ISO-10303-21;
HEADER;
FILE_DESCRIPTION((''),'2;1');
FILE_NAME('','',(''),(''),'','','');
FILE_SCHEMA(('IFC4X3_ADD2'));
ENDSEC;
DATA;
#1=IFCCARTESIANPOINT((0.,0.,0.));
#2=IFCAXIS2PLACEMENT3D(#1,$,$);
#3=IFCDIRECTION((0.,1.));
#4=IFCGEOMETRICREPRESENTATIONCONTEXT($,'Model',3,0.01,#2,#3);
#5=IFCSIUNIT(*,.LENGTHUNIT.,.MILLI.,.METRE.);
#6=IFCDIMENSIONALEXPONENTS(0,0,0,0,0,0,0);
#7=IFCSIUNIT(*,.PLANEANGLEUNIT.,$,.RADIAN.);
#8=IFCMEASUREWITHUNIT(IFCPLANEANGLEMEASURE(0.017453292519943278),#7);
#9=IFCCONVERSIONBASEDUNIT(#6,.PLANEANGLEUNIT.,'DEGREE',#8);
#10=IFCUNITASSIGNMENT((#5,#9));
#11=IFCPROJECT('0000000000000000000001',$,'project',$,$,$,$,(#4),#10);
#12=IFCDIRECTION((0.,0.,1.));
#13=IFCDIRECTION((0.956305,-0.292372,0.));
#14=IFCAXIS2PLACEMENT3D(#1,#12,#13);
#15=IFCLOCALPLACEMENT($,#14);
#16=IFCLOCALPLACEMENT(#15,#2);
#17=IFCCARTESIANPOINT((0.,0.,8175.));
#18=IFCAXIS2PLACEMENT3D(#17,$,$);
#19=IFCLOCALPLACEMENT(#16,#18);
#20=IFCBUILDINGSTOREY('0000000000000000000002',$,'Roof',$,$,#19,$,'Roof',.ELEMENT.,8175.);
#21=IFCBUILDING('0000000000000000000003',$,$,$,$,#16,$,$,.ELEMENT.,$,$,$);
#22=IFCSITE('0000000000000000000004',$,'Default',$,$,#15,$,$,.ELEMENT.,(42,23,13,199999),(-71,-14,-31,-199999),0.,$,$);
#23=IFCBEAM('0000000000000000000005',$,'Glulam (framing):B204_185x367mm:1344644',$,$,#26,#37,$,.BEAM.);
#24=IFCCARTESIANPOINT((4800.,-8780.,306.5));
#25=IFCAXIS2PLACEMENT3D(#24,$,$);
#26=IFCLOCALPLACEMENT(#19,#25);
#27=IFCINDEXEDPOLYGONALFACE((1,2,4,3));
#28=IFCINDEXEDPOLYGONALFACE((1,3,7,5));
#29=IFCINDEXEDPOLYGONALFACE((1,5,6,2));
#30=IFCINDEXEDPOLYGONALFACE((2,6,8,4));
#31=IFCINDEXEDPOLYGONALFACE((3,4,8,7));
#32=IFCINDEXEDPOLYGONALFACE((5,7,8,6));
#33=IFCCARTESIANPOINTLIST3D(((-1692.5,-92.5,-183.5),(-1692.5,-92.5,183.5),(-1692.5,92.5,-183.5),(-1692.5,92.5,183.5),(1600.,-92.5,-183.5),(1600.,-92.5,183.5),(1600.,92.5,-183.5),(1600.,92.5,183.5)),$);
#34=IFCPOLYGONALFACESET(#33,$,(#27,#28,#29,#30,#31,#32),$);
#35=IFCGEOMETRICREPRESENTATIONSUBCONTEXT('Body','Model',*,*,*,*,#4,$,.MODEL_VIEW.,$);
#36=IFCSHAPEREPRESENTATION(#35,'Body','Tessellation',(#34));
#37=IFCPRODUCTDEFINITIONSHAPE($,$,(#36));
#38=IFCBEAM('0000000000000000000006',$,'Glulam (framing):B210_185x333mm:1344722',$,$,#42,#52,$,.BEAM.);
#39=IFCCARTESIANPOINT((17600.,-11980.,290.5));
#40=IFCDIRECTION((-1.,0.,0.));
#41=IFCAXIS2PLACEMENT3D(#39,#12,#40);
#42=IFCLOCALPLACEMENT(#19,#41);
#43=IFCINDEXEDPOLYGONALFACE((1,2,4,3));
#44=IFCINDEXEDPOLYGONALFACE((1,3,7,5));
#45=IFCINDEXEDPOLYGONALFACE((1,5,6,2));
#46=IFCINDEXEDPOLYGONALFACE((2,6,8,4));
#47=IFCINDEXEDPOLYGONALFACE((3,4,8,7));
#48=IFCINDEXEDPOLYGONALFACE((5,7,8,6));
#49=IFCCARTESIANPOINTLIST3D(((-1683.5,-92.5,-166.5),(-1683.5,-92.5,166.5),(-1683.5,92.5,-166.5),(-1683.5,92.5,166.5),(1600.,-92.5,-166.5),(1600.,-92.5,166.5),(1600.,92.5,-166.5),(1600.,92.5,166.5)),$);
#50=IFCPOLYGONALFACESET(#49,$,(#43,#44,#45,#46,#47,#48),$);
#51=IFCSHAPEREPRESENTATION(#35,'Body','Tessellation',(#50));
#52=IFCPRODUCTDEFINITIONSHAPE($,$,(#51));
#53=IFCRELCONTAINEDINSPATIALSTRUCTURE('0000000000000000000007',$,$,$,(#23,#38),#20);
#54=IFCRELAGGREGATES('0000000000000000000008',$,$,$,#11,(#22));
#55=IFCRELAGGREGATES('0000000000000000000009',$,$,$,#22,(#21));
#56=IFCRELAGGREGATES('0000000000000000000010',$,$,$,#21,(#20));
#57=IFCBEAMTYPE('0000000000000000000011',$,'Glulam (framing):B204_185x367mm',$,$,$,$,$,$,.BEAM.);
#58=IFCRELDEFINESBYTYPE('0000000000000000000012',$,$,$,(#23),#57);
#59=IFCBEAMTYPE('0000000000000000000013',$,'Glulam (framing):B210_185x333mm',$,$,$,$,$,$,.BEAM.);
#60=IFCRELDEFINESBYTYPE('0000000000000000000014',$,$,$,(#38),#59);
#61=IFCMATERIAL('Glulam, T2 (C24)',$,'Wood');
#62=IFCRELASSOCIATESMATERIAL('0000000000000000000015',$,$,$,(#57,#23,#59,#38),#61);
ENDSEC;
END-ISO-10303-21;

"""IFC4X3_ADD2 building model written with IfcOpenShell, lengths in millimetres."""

from ifc_helpers import new_model, entity, si_unit, converted_unit, direction, frame, origin, origin_2d_with_axis, place, context, subcontext, project, spatial, rectangle, extrude, source, transform, mapped, material, material_profile, profile_set, profile_usage, type_object, type_shapes, element, save


model = new_model("IFC4X3_ADD2")

# Units and contexts
model_context = context("Model", 3, precision=0.01, world=origin(), true_north=direction((0.0, 1.0)))
body_context = subcontext(model_context, "Body", "Model", "MODEL_VIEW")
ifc_project = project(units=[si_unit("LENGTHUNIT", "METRE", prefix="MILLI"), converted_unit("PLANEANGLEUNIT", "DEGREE", entity("IfcPlaneAngleMeasure", 0.017453292519943278), si_unit("PLANEANGLEUNIT", "RADIAN"), dimensions=[0, 0, 0, 0, 0, 0, 0])], contexts=[model_context])

# Site, building, storey
site_placement = place(None, frame((0.0, 0.0, 0.0), z_axis=(0.0, 0.0, 1.0), x_axis=(0.956305, -0.292372, 0.0)))
site = spatial("IfcSite", under=ifc_project, at=site_placement, Name="Default", CompositionType="ELEMENT", RefLatitude=(42, 23, 13, 199999), RefLongitude=(-71, -14, -31, -199999), RefElevation=0.0)
building_placement = place(site_placement, origin())
building = spatial("IfcBuilding", under=site, at=building_placement, CompositionType="ELEMENT")
storey_placement = place(building_placement, frame((0.0, 0.0, 8175.0)))
storey = spatial("IfcBuildingStorey", under=building, at=storey_placement, Name="Roof", LongName="Roof", CompositionType="ELEMENT", Elevation=8175.0)

# Beams
ifc_material_1 = material(Name="Glulam, T2 (C24)", Category="Wood")
ifc_material_profile_1 = material_profile(ifc_material_1, rectangle(XDim=3442.5, YDim=185.0, at=origin_2d_with_axis()), Name="B204_185x367mm")
ifc_profile_set_1 = profile_set([ifc_material_profile_1], Name="B204_185x367mm")
ifc_profile_usage_1 = profile_usage(ifc_profile_set_1, cardinal=8)
beam_type_1 = type_object("IfcBeamType", Name="Glulam (framing):B204_185x367mm", PredefinedType="BEAM", material=ifc_profile_set_1)
shared_shape_1 = source(origin(), body_context, "Body", "SweptSolid", [
    extrude(rectangle(XDim=3292.5, YDim=185.0, at=origin_2d_with_axis()), frame((-46.2, 0.0, -183.5), z_axis=(0.0, 0.0, 1.0), x_axis=(-1.0, 0.0, 0.0)), (0.0, 0.0, 1.0), 367.0),
])
type_shapes(beam_type_1, [shared_shape_1])
beam_1_placement = place(storey_placement, frame((4800.0, -8780.0, 306.5)))
element("IfcBeam", 1, at=beam_1_placement, inside=storey, type_object=beam_type_1, material=ifc_profile_usage_1, Name="Glulam (framing):B204_185x367mm:1344644", PredefinedType="BEAM", context=body_context, shape_type="MappedRepresentation", body=[
    mapped(shared_shape_1, transform((0.0, 0.0, 0.0), scale=1.0)),
])
ifc_material_profile_2 = material_profile(ifc_material_1, rectangle(XDim=185.0, YDim=3200.0, at=origin_2d_with_axis()), Name="B210_185x333mm")
ifc_profile_set_2 = profile_set([ifc_material_profile_2], Name="B210_185x333mm")
ifc_profile_usage_2 = profile_usage(ifc_profile_set_2, cardinal=8)
beam_type_2 = type_object("IfcBeamType", Name="Glulam (framing):B210_185x333mm", PredefinedType="BEAM", material=ifc_profile_set_2)
shared_shape_2 = source(origin(), body_context, "Body", "SweptSolid", [
    extrude(rectangle(XDim=185.0, YDim=3283.5, at=origin_2d_with_axis()), frame((-41.7, 0.0, -166.5), z_axis=(0.0, 0.0, 1.0), x_axis=(0.0, 1.0, 0.0)), (0.0, 0.0, 1.0), 333.0),
])
type_shapes(beam_type_2, [shared_shape_2])
beam_2_placement = place(storey_placement, frame((17600.0, -11980.0, 290.5), z_axis=(0.0, 0.0, 1.0), x_axis=(-1.0, 0.0, 0.0)))
element("IfcBeam", 2, at=beam_2_placement, inside=storey, type_object=beam_type_2, material=ifc_profile_usage_2, Name="Glulam (framing):B210_185x333mm:1344722", PredefinedType="BEAM", context=body_context, shape_type="MappedRepresentation", body=[
    mapped(shared_shape_2, transform((0.0, 0.0, 0.0), scale=1.0)),
])

save(model, "model.ifc")
